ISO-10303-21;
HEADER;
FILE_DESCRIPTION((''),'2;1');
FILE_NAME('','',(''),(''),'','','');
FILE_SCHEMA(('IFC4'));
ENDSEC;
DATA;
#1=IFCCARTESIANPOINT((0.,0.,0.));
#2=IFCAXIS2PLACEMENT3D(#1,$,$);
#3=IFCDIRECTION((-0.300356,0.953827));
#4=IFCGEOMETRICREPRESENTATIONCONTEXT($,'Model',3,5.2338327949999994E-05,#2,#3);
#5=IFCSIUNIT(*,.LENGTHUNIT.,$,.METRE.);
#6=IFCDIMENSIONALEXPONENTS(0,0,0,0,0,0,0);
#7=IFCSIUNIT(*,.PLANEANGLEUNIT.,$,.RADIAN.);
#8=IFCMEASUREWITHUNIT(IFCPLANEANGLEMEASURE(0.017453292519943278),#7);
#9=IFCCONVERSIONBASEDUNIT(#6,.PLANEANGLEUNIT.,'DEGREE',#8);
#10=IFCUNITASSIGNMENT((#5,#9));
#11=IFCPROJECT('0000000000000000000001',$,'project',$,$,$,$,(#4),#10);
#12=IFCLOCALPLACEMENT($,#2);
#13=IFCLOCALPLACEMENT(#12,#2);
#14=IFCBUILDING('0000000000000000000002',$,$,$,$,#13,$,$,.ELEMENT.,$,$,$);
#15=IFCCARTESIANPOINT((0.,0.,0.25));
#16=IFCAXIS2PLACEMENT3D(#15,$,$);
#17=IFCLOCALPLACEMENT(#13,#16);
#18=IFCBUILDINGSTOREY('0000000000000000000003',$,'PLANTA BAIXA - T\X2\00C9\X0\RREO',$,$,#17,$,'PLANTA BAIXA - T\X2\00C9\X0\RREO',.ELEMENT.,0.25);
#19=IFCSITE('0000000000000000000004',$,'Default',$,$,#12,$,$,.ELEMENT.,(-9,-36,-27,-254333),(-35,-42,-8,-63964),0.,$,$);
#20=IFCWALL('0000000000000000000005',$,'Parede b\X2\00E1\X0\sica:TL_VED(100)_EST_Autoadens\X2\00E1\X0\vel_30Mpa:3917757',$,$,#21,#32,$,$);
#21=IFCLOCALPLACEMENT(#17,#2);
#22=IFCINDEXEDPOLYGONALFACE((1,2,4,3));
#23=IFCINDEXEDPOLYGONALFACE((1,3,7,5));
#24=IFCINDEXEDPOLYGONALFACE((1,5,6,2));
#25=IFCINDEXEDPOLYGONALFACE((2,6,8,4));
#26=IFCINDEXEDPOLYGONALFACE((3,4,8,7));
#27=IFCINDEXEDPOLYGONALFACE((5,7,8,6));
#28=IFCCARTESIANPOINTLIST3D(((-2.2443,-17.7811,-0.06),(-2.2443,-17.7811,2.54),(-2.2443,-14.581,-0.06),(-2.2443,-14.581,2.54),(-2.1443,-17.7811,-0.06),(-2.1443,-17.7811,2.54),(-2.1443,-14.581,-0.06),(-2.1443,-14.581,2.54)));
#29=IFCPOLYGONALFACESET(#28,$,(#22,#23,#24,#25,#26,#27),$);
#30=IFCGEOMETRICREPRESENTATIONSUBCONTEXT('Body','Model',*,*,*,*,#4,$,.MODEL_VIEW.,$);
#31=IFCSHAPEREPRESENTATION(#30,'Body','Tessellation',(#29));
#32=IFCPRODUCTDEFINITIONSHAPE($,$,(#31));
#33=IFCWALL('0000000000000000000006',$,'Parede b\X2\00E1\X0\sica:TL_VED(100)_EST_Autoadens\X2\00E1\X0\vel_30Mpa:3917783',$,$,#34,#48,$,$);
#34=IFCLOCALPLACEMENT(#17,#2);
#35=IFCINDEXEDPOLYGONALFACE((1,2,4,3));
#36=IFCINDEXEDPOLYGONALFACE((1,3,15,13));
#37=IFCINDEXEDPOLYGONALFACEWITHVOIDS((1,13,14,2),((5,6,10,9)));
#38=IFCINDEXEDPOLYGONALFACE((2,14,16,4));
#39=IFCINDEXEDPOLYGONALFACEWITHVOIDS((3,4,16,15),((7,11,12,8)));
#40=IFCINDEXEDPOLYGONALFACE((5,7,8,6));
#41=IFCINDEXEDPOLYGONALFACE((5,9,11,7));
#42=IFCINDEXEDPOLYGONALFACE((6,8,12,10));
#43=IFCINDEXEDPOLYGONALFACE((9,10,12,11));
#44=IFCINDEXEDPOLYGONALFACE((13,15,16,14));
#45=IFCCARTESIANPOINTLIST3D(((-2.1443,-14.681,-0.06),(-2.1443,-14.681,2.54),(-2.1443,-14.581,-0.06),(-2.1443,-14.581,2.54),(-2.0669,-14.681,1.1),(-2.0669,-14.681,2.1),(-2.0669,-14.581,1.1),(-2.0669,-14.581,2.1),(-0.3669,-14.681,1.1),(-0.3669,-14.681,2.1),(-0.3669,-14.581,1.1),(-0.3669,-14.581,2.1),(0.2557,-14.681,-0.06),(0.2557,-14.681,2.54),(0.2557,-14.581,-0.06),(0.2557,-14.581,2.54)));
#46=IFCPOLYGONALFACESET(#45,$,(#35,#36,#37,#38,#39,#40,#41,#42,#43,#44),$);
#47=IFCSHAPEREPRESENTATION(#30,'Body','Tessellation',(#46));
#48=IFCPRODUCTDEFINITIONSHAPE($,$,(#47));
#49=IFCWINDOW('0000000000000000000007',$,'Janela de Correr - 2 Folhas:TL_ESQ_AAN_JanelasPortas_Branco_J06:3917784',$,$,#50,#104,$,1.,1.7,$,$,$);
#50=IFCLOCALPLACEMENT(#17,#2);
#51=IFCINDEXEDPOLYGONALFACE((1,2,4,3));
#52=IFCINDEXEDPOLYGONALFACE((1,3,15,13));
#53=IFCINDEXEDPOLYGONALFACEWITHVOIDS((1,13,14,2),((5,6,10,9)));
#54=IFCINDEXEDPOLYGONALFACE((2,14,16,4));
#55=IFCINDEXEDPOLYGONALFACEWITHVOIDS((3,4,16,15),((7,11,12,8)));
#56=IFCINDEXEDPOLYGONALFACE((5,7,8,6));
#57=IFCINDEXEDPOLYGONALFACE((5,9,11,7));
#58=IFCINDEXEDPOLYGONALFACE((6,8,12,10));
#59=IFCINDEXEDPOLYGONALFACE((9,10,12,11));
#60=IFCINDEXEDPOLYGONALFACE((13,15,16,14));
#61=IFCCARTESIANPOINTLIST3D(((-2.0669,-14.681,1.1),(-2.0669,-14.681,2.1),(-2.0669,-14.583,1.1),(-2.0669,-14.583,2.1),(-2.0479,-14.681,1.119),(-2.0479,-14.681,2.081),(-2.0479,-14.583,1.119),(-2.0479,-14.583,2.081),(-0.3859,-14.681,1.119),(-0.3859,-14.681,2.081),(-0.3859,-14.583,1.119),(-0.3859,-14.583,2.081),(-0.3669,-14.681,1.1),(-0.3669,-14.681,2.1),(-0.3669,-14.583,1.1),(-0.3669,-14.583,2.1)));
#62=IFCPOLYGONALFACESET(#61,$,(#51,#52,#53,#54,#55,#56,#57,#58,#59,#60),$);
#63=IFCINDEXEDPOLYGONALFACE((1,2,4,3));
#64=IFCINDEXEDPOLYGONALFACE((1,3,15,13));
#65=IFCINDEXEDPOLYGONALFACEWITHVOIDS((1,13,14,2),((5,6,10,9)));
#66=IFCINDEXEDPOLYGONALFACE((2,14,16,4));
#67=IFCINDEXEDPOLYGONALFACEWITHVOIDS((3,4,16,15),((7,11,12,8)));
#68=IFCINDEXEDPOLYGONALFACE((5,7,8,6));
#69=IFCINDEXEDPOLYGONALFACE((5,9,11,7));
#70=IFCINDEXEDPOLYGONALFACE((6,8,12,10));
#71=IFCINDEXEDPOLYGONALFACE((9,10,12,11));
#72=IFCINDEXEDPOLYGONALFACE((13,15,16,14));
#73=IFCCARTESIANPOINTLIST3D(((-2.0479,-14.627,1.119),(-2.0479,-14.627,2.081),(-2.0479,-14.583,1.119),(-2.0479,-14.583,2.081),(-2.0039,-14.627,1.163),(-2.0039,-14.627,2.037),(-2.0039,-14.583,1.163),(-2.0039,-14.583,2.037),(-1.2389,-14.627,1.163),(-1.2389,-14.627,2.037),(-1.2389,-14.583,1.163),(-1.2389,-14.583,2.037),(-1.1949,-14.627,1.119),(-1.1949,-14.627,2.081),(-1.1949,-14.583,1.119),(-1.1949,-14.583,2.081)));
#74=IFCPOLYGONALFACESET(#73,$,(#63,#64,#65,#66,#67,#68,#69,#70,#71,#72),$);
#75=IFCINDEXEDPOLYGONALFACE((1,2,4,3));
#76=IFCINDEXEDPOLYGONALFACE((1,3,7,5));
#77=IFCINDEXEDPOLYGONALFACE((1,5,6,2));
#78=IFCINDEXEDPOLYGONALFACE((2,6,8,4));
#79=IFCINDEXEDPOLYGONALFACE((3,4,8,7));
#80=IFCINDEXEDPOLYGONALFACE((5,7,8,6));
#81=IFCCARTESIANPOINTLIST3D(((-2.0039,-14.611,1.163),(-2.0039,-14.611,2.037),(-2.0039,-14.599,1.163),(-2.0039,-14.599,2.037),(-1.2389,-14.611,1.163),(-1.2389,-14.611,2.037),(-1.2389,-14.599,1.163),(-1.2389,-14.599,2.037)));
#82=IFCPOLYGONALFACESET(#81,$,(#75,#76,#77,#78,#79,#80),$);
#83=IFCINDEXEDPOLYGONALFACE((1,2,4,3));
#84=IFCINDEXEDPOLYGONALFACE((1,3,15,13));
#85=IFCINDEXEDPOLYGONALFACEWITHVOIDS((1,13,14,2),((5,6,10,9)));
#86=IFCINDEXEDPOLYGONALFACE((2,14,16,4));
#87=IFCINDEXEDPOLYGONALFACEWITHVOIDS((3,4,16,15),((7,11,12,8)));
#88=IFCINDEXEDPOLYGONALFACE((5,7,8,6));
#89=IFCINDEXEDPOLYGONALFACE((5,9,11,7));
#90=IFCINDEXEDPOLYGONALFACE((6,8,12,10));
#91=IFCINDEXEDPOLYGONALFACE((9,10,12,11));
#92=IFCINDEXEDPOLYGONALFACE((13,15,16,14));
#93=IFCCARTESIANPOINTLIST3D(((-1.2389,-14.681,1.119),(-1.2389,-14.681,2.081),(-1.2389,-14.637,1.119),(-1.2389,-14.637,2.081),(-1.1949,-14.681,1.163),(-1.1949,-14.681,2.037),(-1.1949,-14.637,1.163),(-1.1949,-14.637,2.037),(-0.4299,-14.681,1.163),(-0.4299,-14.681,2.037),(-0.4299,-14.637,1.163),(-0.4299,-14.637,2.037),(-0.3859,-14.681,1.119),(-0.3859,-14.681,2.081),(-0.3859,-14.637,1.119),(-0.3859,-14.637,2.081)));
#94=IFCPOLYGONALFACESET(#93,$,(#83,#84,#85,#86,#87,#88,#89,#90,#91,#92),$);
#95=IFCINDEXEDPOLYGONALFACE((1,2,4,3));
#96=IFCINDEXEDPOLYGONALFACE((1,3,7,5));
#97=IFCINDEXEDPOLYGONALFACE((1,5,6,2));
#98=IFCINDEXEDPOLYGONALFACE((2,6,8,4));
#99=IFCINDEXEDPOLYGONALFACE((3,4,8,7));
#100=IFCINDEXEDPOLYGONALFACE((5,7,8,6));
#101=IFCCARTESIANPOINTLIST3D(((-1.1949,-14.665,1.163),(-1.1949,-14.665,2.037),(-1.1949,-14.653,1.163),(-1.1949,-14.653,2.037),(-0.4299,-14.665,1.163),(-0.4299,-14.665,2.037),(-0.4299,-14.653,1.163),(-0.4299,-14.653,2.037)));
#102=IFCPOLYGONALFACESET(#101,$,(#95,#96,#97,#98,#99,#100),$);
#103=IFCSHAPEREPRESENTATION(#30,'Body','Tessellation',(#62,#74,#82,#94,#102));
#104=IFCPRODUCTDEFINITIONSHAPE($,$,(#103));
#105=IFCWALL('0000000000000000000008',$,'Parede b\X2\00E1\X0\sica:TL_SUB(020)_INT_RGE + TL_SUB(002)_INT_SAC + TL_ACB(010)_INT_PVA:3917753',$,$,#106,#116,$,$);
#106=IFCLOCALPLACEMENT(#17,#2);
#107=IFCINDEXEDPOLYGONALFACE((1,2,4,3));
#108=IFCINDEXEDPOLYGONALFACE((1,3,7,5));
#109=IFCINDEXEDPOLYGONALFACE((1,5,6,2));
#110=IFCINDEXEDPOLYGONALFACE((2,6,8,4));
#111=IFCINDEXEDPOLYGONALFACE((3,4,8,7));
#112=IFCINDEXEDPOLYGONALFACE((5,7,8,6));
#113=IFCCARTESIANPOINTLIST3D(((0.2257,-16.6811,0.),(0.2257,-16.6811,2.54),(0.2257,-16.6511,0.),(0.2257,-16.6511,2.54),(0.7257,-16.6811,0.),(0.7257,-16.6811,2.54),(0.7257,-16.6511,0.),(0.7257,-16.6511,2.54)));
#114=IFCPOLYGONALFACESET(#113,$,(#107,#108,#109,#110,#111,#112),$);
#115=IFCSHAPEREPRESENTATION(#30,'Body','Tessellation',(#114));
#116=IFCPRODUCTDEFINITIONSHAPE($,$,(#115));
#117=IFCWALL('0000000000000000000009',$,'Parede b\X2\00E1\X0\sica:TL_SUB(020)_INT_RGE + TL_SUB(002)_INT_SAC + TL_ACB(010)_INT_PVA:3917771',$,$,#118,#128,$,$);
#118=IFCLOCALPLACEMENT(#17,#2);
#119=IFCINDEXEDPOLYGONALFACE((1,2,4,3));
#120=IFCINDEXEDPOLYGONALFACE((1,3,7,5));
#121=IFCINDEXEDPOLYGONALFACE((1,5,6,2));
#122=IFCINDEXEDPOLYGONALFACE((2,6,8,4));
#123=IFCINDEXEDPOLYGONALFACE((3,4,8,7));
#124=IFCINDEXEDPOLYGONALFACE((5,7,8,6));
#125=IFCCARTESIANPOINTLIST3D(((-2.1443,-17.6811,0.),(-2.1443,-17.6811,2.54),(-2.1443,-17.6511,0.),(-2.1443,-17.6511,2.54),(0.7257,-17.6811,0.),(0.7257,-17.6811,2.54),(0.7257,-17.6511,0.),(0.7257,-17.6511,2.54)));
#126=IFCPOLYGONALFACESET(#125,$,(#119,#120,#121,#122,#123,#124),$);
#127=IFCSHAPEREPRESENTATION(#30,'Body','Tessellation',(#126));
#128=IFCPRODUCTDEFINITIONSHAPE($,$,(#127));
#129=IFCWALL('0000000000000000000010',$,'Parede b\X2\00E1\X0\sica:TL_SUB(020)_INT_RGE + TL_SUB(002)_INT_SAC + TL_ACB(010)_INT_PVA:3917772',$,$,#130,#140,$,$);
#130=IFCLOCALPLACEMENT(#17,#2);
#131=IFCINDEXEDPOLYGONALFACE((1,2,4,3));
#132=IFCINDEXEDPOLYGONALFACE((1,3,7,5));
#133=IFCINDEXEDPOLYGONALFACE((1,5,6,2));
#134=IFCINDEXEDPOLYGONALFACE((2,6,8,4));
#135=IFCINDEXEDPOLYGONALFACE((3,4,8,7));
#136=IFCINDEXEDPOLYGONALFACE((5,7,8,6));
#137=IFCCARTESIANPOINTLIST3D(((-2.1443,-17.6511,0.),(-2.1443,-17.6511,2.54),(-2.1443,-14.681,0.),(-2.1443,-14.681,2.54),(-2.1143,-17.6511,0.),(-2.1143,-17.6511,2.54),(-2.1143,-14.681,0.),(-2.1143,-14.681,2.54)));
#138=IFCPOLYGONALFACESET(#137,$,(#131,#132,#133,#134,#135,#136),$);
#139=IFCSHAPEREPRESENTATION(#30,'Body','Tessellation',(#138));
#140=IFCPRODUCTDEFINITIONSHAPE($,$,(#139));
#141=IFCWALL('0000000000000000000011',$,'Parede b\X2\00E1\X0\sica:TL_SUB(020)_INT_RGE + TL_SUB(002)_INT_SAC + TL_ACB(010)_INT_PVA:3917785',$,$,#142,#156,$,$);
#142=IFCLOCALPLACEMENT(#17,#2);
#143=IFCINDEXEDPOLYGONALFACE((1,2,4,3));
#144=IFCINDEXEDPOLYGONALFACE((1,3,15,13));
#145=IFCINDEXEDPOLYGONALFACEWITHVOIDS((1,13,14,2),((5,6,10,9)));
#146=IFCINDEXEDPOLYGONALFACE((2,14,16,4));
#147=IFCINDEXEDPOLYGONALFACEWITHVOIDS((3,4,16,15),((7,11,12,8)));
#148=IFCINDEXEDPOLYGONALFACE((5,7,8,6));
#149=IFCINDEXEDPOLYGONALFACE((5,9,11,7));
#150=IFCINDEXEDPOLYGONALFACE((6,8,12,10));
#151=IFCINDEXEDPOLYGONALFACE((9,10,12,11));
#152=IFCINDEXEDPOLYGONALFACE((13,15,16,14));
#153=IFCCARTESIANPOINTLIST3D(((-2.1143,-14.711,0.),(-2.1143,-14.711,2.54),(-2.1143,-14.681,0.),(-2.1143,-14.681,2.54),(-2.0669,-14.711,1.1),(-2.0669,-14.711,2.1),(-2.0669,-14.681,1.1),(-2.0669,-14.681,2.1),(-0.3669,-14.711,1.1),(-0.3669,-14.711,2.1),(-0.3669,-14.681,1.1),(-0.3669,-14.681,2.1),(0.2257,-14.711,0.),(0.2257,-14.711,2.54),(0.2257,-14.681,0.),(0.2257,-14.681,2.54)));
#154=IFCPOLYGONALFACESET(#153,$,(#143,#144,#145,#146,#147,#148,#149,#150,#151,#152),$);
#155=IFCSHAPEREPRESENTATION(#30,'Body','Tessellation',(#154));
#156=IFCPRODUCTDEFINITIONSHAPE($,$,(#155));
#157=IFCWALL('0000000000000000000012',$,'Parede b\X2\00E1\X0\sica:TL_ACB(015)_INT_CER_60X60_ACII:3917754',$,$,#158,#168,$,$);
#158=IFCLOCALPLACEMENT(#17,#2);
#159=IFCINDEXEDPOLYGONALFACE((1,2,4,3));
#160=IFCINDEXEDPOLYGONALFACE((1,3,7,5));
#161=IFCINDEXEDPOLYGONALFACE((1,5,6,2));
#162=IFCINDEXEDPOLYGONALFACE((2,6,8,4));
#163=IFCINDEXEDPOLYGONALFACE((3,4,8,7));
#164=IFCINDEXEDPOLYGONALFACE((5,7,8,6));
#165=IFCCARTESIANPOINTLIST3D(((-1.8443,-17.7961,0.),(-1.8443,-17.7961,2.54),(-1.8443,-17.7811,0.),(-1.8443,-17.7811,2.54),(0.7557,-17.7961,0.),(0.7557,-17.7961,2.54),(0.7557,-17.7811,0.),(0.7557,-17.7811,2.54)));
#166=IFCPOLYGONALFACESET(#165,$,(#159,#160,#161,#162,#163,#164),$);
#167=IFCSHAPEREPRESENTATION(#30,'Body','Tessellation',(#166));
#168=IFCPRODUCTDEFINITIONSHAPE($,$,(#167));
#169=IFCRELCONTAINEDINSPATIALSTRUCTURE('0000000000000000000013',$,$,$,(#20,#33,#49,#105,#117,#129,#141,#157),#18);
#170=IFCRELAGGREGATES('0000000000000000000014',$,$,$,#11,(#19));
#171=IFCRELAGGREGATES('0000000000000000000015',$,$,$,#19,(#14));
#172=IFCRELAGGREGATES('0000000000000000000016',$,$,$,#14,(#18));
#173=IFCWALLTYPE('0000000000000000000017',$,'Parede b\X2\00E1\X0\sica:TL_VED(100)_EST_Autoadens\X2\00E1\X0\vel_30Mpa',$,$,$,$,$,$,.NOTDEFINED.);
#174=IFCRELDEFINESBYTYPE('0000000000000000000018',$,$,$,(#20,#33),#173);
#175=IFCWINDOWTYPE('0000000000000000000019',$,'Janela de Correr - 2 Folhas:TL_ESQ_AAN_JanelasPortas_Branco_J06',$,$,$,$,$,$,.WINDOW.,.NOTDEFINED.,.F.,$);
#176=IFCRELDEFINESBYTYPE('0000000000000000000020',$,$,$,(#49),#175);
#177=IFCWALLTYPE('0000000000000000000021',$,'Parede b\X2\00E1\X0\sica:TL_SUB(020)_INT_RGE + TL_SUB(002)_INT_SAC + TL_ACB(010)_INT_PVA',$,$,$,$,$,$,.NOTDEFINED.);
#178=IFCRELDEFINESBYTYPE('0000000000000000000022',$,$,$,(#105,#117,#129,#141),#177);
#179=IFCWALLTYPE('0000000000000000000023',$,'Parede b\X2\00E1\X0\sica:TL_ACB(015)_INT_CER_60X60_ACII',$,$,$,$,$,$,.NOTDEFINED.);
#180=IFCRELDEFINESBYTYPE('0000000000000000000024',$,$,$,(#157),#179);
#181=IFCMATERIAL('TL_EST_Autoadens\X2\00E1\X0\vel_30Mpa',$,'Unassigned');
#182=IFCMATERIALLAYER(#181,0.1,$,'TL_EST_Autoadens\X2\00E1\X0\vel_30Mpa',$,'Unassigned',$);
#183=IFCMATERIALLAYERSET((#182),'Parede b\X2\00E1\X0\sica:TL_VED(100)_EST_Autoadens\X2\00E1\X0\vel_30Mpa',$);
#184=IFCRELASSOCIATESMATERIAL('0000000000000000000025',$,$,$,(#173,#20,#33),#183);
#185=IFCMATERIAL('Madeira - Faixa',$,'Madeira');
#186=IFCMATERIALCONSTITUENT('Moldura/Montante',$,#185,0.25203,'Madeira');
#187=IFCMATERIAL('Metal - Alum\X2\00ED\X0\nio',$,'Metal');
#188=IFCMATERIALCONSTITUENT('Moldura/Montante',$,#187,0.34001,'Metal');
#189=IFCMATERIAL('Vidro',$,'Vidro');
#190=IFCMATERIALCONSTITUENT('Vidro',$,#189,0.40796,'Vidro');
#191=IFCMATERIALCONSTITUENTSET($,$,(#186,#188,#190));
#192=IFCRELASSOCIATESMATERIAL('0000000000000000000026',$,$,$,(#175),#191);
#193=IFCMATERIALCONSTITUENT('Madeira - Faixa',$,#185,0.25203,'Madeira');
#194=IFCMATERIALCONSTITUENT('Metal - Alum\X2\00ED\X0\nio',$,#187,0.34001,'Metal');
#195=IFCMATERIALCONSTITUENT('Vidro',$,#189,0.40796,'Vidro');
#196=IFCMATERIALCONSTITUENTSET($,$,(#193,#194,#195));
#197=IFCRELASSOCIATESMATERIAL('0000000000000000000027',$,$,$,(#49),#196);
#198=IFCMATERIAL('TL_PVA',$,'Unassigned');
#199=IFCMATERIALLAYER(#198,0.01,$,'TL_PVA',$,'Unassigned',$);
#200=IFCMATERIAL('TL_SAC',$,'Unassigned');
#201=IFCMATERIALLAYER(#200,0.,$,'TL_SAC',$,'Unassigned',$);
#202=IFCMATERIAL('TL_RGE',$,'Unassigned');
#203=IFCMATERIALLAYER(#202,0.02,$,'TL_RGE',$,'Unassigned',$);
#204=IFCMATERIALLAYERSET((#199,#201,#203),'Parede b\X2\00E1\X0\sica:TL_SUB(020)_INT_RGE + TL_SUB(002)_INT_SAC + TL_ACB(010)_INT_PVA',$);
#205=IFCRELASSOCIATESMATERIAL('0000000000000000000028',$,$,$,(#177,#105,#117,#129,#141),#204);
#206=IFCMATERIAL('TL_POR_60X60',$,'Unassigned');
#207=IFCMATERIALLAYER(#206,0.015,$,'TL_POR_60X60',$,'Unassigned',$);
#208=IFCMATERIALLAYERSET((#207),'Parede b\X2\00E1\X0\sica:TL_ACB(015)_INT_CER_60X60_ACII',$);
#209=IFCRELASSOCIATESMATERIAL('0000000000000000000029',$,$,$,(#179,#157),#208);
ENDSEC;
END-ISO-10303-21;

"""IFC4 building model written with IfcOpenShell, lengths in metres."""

from ifc_helpers import new_model, entity, si_unit, converted_unit, direction, frame, frame_2d, origin, origin_2d_with_axis, place, context, subcontext, project, spatial, polyline, rectangle, outline, extrude, source, transform, mapped, material, layer, layer_set, layer_usage, constituent, constituent_set, type_object, type_shapes, element, fill, save


model = new_model("IFC4")

# Units and contexts
model_context = context("Model", 3, precision=5.2338327949999994e-05, world=origin(), true_north=direction((-0.300356, 0.953827)))
body_context = subcontext(model_context, "Body", "Model", "MODEL_VIEW")
ifc_project = project(units=[si_unit("LENGTHUNIT", "METRE"), converted_unit("PLANEANGLEUNIT", "DEGREE", entity("IfcPlaneAngleMeasure", 0.017453292519943278), si_unit("PLANEANGLEUNIT", "RADIAN"), dimensions=[0, 0, 0, 0, 0, 0, 0])], contexts=[model_context])

# Site, building, storey
site_placement = place(None, origin())
site = spatial("IfcSite", under=ifc_project, at=site_placement, Name="Default", CompositionType="ELEMENT", RefLatitude=(-9, -36, -27, -254333), RefLongitude=(-35, -42, -8, -63964), RefElevation=0.0)
building_placement = place(site_placement, origin())
building = spatial("IfcBuilding", under=site, at=building_placement, CompositionType="ELEMENT")
storey_placement = place(building_placement, frame((0.0, 0.0, 0.25)))
storey = spatial("IfcBuildingStorey", under=building, at=storey_placement, Name="PLANTA BAIXA - TÉRREO", LongName="PLANTA BAIXA - TÉRREO", CompositionType="ELEMENT", Elevation=0.25)

# Shared definitions
ifc_material_1 = material(Name="TL_POR_60X60", Category="Unassigned")

# Wall
ifc_material_2 = material(Name="TL_EST_Autoadensável_30Mpa", Category="Unassigned")
ifc_layer_1 = layer(ifc_material_2, 0.1, Name="TL_EST_Autoadensável_30Mpa", Category="Unassigned")
ifc_layer_set_1 = layer_set([ifc_layer_1], Name="Parede básica:TL_VED(100)_EST_Autoadensável_30Mpa")
ifc_layer_usage_1 = layer_usage(ifc_layer_set_1, "AXIS2", "NEGATIVE", 0.05)
wall_type_1 = type_object("IfcWallType", Name="Parede básica:TL_VED(100)_EST_Autoadensável_30Mpa", PredefinedType="NOTDEFINED", material=ifc_layer_set_1)
wall_1_placement = place(storey_placement, frame((-2.1943, -14.581, -0.06), z_axis=(0.0, 0.0, 1.0), x_axis=(0.0, -1.0, 0.0)))
element("IfcWall", 1, at=wall_1_placement, inside=storey, type_object=wall_type_1, material=ifc_layer_usage_1, Name="Parede básica:TL_VED(100)_EST_Autoadensável_30Mpa:3917757", context=body_context, shape_type="SweptSolid", body=[
    extrude(rectangle(XDim=3.2001, YDim=0.1, at=frame_2d((1.6001, 0.0), x_axis=(-1.0, 0.0))), origin(), (0.0, 0.0, 1.0), 2.6),
])

# Wall, opening, window
ifc_layer_usage_2 = layer_usage(ifc_layer_set_1, "AXIS2", "NEGATIVE", 0.05)
wall_2_placement = place(storey_placement, frame((-2.1443, -14.631, -0.06)))
wall_2 = element("IfcWall", 2, at=wall_2_placement, inside=storey, type_object=wall_type_1, material=ifc_layer_usage_2, Name="Parede básica:TL_VED(100)_EST_Autoadensável_30Mpa:3917783", context=body_context, shape_type="SweptSolid", body=[
    extrude(rectangle(XDim=2.4, YDim=0.1, at=frame_2d((1.2, 0.0), x_axis=(-1.0, 0.0))), origin(), (0.0, 0.0, 1.0), 2.6),
])
opening_1_placement = place(wall_2_placement, frame((0.0774, -0.05, 1.16)))
opening_1 = element("IfcOpeningElement", 3, at=opening_1_placement, cuts=wall_2, PredefinedType="OPENING", context=body_context, shape_type="SweptSolid", body=[
    extrude(rectangle(XDim=1.0, YDim=1.7, at=frame_2d((0.5, 0.85), x_axis=(-1.0, 0.0))), frame((0.0, 0.0, 0.0), z_axis=(0.0, 1.0, 0.0), x_axis=(0.0, 0.0, 1.0)), (0.0, 0.0, 1.0), 0.1),
])
ifc_material_3 = material(Name="Madeira - Faixa", Category="Madeira")
ifc_constituent_1 = constituent(ifc_material_3, Name="Madeira - Faixa", Category="Madeira", fraction=0.25203)
ifc_material_4 = material(Name="Metal - Alumínio", Category="Metal")
ifc_constituent_2 = constituent(ifc_material_4, Name="Metal - Alumínio", Category="Metal", fraction=0.34001)
ifc_material_5 = material(Name="Vidro", Category="Vidro")
ifc_constituent_3 = constituent(ifc_material_5, Name="Vidro", Category="Vidro", fraction=0.40796)
ifc_constituent_set_1 = constituent_set(constituents=[ifc_constituent_1, ifc_constituent_2, ifc_constituent_3])
ifc_constituent_4 = constituent(ifc_material_3, Name="Moldura/Montante", Category="Madeira", fraction=0.25203)
ifc_constituent_5 = constituent(ifc_material_4, Name="Moldura/Montante", Category="Metal", fraction=0.34001)
ifc_constituent_6 = constituent(ifc_material_5, Name="Vidro", Category="Vidro", fraction=0.40796)
ifc_constituent_set_2 = constituent_set(constituents=[ifc_constituent_4, ifc_constituent_5, ifc_constituent_6])
window_type = type_object("IfcWindowType", Name="Janela de Correr - 2 Folhas:TL_ESQ_AAN_JanelasPortas_Branco_J06", ParameterTakesPrecedence=False, PartitioningType="NOTDEFINED", PredefinedType="WINDOW", material=ifc_constituent_set_2)
shared_shape_1 = source(origin(), body_context, "Body", "SweptSolid", [
    extrude(outline(polyline([(-0.85, -0.5), (0.85, -0.5), (0.85, 0.5), (-0.85, 0.5), (-0.85, -0.5)]), holes=[polyline([(-0.831, -0.481), (-0.831, 0.481), (0.831, 0.481), (0.831, -0.481), (-0.831, -0.481)])]), frame((0.85, 0.124, 0.5), z_axis=(0.0, -1.0, 0.0), x_axis=(-1.0, 0.0, 0.0)), (0.0, 0.0, 1.0), 0.098),
    extrude(outline(polyline([(-0.4265, -0.481), (0.4265, -0.481), (0.4265, 0.481), (-0.4265, 0.481), (-0.4265, -0.481)]), holes=[polyline([(-0.3825, -0.437), (-0.3825, 0.437), (0.3825, 0.437), (0.3825, -0.437), (-0.3825, -0.437)])]), frame((0.4455, 0.124, 0.5), z_axis=(0.0, -1.0, 0.0), x_axis=(-1.0, 0.0, 0.0)), (0.0, 0.0, 1.0), 0.044),
    extrude(rectangle(XDim=0.765, YDim=0.012, at=origin_2d_with_axis()), frame((0.4455, 0.102, 0.063), z_axis=(0.0, 0.0, 1.0), x_axis=(-1.0, 0.0, 0.0)), (0.0, 0.0, 1.0), 0.874),
    extrude(outline(polyline([(-0.481, -0.4265), (0.481, -0.4265), (0.481, 0.4265), (-0.481, 0.4265), (-0.481, -0.4265)]), holes=[polyline([(-0.437, -0.3825), (-0.437, 0.3825), (0.437, 0.3825), (0.437, -0.3825), (-0.437, -0.3825)])]), frame((1.2545, 0.07, 0.5), z_axis=(0.0, -1.0, 0.0), x_axis=(0.0, 0.0, -1.0)), (0.0, 0.0, 1.0), 0.044),
    extrude(rectangle(XDim=0.765, YDim=0.012, at=origin_2d_with_axis()), frame((1.2545, 0.048, 0.063), z_axis=(0.0, 0.0, 1.0), x_axis=(-1.0, 0.0, 0.0)), (0.0, 0.0, 1.0), 0.874),
])
type_shapes(window_type, [shared_shape_1])
window_placement = place(opening_1_placement, frame((0.0, -0.026, 0.0)))
window = element("IfcWindow", 4, at=window_placement, inside=storey, type_object=window_type, material=ifc_constituent_set_1, Name="Janela de Correr - 2 Folhas:TL_ESQ_AAN_JanelasPortas_Branco_J06:3917784", OverallHeight=1.0, OverallWidth=1.7, context=body_context, shape_type="MappedRepresentation", body=[
    mapped(shared_shape_1, transform((0.0, 0.0, 0.0), scale=1.0)),
])
fill(opening_1, window)

# Walls
ifc_material_6 = material(Name="TL_PVA", Category="Unassigned")
ifc_layer_2 = layer(ifc_material_6, 0.01, Name="TL_PVA", Category="Unassigned")
ifc_material_7 = material(Name="TL_SAC", Category="Unassigned")
ifc_layer_3 = layer(ifc_material_7, 0.0, Name="TL_SAC", Category="Unassigned")
ifc_material_8 = material(Name="TL_RGE", Category="Unassigned")
ifc_layer_4 = layer(ifc_material_8, 0.02, Name="TL_RGE", Category="Unassigned")
ifc_layer_set_2 = layer_set([ifc_layer_2, ifc_layer_3, ifc_layer_4], Name="Parede básica:TL_SUB(020)_INT_RGE + TL_SUB(002)_INT_SAC + TL_ACB(010)_INT_PVA")
ifc_layer_usage_3 = layer_usage(ifc_layer_set_2, "AXIS2", "POSITIVE", -0.015)
wall_type_2 = type_object("IfcWallType", Name="Parede básica:TL_SUB(020)_INT_RGE + TL_SUB(002)_INT_SAC + TL_ACB(010)_INT_PVA", PredefinedType="NOTDEFINED", material=ifc_layer_set_2)
wall_3_placement = place(storey_placement, frame((0.2257, -16.6661, 0.0)))
element("IfcWall", 5, at=wall_3_placement, inside=storey, type_object=wall_type_2, material=ifc_layer_usage_3, Name="Parede básica:TL_SUB(020)_INT_RGE + TL_SUB(002)_INT_SAC + TL_ACB(010)_INT_PVA:3917753", context=body_context, shape_type="SweptSolid", body=[
    extrude(rectangle(XDim=0.5, YDim=0.03, at=frame_2d((0.25, 0.0), x_axis=(-1.0, 0.0))), origin(), (0.0, 0.0, 1.0), 2.54),
])
ifc_layer_usage_4 = layer_usage(ifc_layer_set_2, "AXIS2", "NEGATIVE", 0.015)
wall_4_placement = place(storey_placement, frame((-2.1443, -17.6661, 0.0)))
element("IfcWall", 6, at=wall_4_placement, inside=storey, type_object=wall_type_2, material=ifc_layer_usage_4, Name="Parede básica:TL_SUB(020)_INT_RGE + TL_SUB(002)_INT_SAC + TL_ACB(010)_INT_PVA:3917771", context=body_context, shape_type="SweptSolid", body=[
    extrude(rectangle(XDim=2.87, YDim=0.03, at=frame_2d((1.435, 0.0), x_axis=(-1.0, 0.0))), origin(), (0.0, 0.0, 1.0), 2.54),
])
ifc_layer_usage_5 = layer_usage(ifc_layer_set_2, "AXIS2", "NEGATIVE", 0.015)
wall_5_placement = place(storey_placement, frame((-2.1293, -14.681, 0.0), z_axis=(0.0, 0.0, 1.0), x_axis=(0.0, -1.0, 0.0)))
element("IfcWall", 7, at=wall_5_placement, inside=storey, type_object=wall_type_2, material=ifc_layer_usage_5, Name="Parede básica:TL_SUB(020)_INT_RGE + TL_SUB(002)_INT_SAC + TL_ACB(010)_INT_PVA:3917772", context=body_context, shape_type="SweptSolid", body=[
    extrude(rectangle(XDim=2.9701, YDim=0.03, at=frame_2d((1.4851, 0.0), x_axis=(-1.0, 0.0))), origin(), (0.0, 0.0, 1.0), 2.54),
])

# Wall, opening
ifc_layer_usage_6 = layer_usage(ifc_layer_set_2, "AXIS2", "NEGATIVE", 0.015)
wall_6_placement = place(storey_placement, frame((0.2257, -14.696, 0.0), z_axis=(0.0, 0.0, 1.0), x_axis=(-1.0, 0.0, 0.0)))
wall_6 = element("IfcWall", 8, at=wall_6_placement, inside=storey, type_object=wall_type_2, material=ifc_layer_usage_6, Name="Parede básica:TL_SUB(020)_INT_RGE + TL_SUB(002)_INT_SAC + TL_ACB(010)_INT_PVA:3917785", context=body_context, shape_type="SweptSolid", body=[
    extrude(rectangle(XDim=2.34, YDim=0.03, at=frame_2d((1.17, 0.0), x_axis=(-1.0, 0.0))), origin(), (0.0, 0.0, 1.0), 2.54),
])
opening_2_placement = place(wall_6_placement, frame((0.2257, -14.696, 1.1)))
element("IfcOpeningElement", 9, at=opening_2_placement, cuts=wall_6, PredefinedType="OPENING", context=body_context, shape_type="SweptSolid", body=[
    extrude(rectangle(XDim=1.0, YDim=1.7, at=frame_2d((0.0, 0.0), x_axis=(0.0, 1.0))), frame((1.2169, 13.157, 0.5), z_axis=(0.0, 1.0, 0.0), x_axis=(1.0, 0.0, 0.0)), (0.0, 0.0, 1.0), 3.048),
])

# Wall
ifc_layer_5 = layer(ifc_material_1, 0.015, Name="TL_POR_60X60", Category="Unassigned")
ifc_layer_set_3 = layer_set([ifc_layer_5], Name="Parede básica:TL_ACB(015)_INT_CER_60X60_ACII")
ifc_layer_usage_7 = layer_usage(ifc_layer_set_3, "AXIS2", "POSITIVE", -0.0075)
wall_type_3 = type_object("IfcWallType", Name="Parede básica:TL_ACB(015)_INT_CER_60X60_ACII", PredefinedType="NOTDEFINED", material=ifc_layer_set_3)
wall_7_placement = place(storey_placement, frame((-1.8443, -17.7886, 0.0)))
element("IfcWall", 10, at=wall_7_placement, inside=storey, type_object=wall_type_3, material=ifc_layer_usage_7, Name="Parede básica:TL_ACB(015)_INT_CER_60X60_ACII:3917754", context=body_context, shape_type="SweptSolid", body=[
    extrude(rectangle(XDim=2.6, YDim=0.015, at=frame_2d((1.3, 0.0), x_axis=(-1.0, 0.0))), origin(), (0.0, 0.0, 1.0), 2.54),
])

save(model, "model.ifc")
